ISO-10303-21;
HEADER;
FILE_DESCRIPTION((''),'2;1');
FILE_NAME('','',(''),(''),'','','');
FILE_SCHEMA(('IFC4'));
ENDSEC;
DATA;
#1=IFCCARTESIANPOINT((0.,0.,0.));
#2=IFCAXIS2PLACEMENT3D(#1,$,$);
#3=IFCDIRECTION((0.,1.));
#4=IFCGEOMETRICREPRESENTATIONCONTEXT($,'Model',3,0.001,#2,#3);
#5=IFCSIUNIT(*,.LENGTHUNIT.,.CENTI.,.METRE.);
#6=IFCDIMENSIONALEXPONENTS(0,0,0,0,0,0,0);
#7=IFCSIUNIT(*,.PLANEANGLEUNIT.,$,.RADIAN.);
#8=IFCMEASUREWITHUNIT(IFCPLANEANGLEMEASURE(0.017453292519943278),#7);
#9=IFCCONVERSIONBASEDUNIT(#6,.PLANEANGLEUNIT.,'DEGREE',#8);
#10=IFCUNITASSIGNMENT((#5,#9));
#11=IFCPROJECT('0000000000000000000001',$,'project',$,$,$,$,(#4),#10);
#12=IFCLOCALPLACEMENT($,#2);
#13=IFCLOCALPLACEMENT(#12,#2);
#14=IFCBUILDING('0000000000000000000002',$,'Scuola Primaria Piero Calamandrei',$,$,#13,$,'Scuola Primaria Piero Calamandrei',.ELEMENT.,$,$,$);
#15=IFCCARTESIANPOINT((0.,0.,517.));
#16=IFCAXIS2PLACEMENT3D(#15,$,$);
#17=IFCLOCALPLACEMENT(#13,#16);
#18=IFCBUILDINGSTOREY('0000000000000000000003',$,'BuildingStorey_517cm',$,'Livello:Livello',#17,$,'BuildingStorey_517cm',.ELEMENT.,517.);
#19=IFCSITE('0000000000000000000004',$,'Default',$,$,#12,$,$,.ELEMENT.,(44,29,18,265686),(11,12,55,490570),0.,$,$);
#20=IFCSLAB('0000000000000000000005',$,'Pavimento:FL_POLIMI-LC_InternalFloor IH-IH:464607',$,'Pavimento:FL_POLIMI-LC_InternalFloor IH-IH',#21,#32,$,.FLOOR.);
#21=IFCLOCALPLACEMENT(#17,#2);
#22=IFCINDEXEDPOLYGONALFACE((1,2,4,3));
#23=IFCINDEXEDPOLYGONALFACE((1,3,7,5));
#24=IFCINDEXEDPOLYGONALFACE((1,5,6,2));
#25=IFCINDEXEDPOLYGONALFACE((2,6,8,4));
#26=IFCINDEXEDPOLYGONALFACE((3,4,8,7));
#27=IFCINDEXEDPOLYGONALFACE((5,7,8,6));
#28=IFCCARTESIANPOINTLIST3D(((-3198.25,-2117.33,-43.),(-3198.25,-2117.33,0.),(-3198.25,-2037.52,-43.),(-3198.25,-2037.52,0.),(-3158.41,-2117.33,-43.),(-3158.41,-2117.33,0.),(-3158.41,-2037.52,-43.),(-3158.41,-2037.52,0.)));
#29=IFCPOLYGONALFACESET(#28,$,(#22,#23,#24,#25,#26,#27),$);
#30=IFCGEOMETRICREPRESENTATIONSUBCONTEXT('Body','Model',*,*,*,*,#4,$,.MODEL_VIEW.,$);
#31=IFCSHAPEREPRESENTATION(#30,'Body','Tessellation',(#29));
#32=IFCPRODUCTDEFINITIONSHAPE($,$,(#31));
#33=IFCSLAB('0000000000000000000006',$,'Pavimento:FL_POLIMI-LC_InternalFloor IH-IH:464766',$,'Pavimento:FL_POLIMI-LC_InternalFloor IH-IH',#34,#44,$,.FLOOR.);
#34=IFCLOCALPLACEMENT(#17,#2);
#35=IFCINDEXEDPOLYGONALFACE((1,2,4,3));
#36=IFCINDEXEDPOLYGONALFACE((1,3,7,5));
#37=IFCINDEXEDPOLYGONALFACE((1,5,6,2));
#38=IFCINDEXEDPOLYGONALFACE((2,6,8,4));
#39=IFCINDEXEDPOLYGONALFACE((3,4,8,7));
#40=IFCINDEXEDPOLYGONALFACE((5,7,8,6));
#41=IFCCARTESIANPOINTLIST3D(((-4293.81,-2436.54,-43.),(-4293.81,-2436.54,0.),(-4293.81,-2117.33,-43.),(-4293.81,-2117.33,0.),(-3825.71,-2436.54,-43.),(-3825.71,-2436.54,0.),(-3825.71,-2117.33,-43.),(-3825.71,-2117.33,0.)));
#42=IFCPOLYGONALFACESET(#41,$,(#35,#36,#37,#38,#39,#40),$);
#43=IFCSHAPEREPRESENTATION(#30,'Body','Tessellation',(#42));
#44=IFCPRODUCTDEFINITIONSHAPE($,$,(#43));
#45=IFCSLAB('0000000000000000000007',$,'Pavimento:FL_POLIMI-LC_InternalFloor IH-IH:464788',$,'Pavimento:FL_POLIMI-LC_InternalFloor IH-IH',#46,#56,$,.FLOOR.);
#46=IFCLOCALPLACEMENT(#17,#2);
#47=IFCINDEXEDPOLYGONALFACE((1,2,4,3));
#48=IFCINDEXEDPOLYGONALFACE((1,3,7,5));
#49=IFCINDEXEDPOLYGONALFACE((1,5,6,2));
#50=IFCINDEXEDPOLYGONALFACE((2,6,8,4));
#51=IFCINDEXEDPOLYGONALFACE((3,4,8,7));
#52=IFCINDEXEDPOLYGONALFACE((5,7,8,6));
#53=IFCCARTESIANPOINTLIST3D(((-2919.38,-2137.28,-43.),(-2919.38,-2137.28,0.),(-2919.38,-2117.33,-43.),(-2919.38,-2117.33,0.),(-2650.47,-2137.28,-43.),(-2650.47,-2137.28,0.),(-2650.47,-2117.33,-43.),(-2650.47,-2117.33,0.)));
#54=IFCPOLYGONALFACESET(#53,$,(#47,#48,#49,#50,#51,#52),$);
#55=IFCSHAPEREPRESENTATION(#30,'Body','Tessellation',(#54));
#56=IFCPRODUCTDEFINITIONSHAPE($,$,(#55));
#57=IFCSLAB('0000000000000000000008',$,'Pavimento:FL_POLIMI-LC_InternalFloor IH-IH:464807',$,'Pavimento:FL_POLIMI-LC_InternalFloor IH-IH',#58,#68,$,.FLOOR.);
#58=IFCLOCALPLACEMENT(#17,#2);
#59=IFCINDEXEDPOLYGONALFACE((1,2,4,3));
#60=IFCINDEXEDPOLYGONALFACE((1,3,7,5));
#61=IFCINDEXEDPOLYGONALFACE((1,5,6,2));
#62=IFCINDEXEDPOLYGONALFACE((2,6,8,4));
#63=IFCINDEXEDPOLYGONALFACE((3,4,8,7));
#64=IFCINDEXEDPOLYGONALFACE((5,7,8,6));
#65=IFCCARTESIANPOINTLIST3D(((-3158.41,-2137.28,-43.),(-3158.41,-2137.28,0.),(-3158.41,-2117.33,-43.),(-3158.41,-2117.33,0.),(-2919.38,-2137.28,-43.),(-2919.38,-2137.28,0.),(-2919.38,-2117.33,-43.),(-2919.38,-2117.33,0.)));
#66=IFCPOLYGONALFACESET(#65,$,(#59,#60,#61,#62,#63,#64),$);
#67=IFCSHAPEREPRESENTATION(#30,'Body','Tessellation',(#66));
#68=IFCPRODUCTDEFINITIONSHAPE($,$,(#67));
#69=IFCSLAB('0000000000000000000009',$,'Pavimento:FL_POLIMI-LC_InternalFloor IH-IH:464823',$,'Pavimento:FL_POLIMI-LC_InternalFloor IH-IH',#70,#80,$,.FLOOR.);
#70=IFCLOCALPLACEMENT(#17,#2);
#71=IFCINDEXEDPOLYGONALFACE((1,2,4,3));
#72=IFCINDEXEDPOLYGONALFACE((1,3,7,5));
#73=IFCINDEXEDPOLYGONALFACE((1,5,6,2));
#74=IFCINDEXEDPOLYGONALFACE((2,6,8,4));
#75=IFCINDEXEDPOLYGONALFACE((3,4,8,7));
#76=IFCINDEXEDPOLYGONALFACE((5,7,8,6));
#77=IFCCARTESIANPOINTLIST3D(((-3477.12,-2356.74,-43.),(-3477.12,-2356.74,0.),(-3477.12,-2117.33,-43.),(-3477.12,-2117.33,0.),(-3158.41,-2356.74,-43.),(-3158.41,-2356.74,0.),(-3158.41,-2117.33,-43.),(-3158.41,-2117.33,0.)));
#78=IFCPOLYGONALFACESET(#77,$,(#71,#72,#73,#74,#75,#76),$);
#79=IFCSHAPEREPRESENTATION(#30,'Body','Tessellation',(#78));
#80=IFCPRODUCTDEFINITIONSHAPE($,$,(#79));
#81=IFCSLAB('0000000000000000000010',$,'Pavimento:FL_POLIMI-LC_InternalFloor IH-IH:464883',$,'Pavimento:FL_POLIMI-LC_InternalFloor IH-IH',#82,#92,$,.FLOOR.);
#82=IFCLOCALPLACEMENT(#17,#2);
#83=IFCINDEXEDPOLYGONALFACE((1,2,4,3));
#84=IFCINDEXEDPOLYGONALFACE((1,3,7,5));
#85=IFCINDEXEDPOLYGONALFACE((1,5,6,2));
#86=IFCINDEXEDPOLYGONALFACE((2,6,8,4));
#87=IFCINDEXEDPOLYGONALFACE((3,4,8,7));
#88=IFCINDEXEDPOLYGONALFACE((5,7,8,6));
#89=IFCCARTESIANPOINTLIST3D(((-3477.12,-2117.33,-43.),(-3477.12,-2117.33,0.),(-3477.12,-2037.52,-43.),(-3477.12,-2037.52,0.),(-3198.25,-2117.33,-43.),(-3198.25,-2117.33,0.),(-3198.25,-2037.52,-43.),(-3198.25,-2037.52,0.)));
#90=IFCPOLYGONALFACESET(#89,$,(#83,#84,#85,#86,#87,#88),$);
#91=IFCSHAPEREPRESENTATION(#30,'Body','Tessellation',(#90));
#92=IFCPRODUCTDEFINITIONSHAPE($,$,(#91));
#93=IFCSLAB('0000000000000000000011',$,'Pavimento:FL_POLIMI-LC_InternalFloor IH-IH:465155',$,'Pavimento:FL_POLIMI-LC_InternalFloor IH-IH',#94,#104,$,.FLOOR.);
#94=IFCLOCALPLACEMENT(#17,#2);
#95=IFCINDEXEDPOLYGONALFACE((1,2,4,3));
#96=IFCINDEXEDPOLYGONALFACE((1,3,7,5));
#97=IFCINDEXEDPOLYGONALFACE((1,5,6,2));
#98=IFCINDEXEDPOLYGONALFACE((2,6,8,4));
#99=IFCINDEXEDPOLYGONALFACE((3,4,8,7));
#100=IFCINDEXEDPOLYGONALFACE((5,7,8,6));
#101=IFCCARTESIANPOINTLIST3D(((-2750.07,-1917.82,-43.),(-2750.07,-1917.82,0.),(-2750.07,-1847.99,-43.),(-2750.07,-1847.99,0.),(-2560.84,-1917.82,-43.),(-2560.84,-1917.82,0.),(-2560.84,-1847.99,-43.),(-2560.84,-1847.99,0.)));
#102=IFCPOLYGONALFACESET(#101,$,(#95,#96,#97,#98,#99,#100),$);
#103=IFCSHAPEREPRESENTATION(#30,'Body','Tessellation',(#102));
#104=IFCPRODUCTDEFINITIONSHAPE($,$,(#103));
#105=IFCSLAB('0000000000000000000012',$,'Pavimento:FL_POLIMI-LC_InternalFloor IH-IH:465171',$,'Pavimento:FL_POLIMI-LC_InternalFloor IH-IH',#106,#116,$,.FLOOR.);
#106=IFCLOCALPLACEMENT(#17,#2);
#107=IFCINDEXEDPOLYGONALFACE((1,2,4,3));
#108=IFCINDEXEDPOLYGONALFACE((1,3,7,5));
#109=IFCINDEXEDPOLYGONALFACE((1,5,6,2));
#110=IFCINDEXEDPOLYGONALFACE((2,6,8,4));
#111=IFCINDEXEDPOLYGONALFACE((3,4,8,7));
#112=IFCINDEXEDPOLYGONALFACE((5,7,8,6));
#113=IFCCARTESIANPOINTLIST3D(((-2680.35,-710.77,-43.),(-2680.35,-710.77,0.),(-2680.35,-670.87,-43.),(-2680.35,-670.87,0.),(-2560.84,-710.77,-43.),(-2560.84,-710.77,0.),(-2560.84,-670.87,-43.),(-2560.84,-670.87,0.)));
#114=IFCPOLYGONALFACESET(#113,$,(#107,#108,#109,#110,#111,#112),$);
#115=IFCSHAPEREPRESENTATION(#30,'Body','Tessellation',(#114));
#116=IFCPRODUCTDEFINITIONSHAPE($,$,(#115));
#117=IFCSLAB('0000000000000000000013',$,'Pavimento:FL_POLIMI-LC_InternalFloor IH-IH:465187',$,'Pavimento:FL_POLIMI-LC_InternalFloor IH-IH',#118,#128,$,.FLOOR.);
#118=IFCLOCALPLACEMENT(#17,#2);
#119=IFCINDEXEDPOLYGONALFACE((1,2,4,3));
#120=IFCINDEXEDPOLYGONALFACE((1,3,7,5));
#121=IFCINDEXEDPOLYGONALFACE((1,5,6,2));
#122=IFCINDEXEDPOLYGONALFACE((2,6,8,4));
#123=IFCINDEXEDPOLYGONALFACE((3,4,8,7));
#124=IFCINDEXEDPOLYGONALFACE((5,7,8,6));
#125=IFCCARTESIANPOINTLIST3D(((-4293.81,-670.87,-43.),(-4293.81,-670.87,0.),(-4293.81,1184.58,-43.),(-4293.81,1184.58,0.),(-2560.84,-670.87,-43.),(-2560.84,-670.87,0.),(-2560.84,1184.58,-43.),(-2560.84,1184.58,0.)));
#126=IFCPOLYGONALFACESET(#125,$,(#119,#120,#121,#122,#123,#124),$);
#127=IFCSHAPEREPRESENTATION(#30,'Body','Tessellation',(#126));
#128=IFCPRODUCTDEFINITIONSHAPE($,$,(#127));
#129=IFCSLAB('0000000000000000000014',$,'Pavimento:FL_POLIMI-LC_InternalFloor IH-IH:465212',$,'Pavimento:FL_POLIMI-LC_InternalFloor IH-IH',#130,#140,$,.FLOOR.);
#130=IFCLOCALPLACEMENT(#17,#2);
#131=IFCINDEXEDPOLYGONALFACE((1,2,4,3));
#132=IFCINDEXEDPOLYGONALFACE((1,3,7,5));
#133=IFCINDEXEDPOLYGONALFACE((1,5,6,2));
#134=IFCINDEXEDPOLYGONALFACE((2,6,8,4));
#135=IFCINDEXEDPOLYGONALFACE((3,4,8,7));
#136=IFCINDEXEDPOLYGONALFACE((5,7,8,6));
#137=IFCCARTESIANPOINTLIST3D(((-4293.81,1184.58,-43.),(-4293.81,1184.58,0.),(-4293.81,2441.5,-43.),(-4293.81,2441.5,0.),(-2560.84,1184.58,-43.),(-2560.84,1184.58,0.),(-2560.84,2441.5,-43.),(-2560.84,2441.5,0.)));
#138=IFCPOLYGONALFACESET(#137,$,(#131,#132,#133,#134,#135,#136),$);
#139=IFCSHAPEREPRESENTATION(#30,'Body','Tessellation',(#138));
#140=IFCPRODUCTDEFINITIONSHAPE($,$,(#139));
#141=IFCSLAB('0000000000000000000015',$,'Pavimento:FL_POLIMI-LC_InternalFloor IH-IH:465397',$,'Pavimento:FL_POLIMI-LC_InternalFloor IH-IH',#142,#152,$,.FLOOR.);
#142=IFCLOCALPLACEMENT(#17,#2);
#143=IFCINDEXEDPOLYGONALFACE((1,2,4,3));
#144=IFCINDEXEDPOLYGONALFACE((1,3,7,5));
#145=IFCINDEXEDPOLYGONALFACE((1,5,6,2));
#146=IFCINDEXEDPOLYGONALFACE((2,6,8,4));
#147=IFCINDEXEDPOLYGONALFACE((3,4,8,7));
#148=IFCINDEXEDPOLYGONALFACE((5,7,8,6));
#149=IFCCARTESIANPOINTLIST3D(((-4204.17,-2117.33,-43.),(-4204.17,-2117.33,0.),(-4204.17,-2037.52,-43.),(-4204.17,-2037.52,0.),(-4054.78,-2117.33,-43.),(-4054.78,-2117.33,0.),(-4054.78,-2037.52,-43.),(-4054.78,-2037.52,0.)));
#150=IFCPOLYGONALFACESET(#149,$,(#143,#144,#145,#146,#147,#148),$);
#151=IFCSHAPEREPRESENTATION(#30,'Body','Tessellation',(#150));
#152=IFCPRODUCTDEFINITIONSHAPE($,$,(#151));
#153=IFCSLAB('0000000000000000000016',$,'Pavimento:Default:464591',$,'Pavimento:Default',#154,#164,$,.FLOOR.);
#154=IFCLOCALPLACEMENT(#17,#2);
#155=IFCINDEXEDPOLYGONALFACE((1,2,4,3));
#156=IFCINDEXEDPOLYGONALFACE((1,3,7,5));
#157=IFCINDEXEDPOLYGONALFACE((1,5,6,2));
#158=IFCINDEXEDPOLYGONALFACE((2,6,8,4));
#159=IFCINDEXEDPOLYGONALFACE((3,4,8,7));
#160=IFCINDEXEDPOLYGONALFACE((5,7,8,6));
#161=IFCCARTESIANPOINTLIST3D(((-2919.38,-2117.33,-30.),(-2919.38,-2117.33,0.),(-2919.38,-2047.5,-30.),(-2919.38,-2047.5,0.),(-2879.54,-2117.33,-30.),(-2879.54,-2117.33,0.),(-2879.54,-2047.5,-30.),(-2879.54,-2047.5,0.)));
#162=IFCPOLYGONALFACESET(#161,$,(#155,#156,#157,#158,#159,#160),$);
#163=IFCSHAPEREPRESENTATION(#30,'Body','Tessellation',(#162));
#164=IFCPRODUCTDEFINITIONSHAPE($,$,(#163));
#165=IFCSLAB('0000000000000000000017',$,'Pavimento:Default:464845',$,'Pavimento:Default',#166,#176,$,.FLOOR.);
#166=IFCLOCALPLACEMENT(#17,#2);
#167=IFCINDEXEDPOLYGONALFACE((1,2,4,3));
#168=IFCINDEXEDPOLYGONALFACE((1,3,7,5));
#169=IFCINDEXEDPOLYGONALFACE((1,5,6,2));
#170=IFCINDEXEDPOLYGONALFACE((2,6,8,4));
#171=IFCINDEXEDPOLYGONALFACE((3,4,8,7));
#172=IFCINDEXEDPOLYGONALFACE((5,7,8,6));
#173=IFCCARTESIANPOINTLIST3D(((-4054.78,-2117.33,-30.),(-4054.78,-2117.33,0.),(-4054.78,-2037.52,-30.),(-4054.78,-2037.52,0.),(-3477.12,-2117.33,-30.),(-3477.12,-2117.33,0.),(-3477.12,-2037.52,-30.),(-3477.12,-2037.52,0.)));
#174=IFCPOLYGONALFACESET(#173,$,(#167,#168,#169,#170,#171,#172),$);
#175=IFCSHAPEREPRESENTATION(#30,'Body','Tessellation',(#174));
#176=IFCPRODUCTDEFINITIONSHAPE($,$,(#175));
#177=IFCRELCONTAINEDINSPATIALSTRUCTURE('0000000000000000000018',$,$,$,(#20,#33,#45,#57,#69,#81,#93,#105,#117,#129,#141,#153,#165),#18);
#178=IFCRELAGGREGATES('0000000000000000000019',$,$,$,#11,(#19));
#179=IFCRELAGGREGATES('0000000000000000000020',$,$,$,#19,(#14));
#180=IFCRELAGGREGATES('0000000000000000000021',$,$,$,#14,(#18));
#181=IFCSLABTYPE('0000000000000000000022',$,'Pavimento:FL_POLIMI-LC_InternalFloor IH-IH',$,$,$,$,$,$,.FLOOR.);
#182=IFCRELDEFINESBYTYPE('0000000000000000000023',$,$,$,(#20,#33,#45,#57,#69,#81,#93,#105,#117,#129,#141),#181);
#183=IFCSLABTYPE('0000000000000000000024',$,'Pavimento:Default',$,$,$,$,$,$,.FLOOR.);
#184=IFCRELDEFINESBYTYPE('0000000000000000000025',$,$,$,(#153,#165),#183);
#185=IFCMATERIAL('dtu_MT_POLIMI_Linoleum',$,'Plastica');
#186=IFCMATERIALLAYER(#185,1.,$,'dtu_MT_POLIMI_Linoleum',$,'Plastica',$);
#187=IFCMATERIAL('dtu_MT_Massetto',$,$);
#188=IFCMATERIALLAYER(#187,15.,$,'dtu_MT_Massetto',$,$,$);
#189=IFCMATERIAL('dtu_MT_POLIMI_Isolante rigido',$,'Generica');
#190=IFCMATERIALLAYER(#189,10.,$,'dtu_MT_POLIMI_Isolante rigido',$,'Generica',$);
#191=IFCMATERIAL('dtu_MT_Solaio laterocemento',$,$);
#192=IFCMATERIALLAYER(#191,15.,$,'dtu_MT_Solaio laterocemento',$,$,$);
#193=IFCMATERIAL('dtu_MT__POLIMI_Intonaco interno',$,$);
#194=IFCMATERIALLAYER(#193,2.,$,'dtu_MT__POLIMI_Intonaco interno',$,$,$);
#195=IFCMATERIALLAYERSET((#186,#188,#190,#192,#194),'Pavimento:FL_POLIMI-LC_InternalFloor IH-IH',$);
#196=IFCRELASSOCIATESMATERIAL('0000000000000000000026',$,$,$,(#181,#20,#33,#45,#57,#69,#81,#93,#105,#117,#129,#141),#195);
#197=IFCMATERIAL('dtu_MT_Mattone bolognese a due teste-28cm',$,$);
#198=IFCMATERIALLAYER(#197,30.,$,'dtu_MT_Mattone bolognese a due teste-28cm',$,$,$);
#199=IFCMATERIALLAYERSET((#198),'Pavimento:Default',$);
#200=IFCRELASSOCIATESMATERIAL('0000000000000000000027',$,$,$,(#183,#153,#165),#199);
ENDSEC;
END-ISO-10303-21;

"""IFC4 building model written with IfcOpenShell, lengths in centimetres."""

from ifc_helpers import new_model, entity, si_unit, converted_unit, direction, frame, frame_2d, origin, origin_2d_with_axis, place, context, subcontext, project, spatial, rectangle, extrude, material, layer, layer_set, layer_usage, type_object, element, save


model = new_model("IFC4")

# Units and contexts
model_context = context("Model", 3, precision=0.001, world=origin(), true_north=direction((0.0, 1.0)))
body_context = subcontext(model_context, "Body", "Model", "MODEL_VIEW")
ifc_project = project(units=[si_unit("LENGTHUNIT", "METRE", prefix="CENTI"), converted_unit("PLANEANGLEUNIT", "DEGREE", entity("IfcPlaneAngleMeasure", 0.017453292519943278), si_unit("PLANEANGLEUNIT", "RADIAN"), dimensions=[0, 0, 0, 0, 0, 0, 0])], contexts=[model_context])

# Site, building, storey
site_placement = place(None, origin())
site = spatial("IfcSite", under=ifc_project, at=site_placement, Name="Default", CompositionType="ELEMENT", RefLatitude=(44, 29, 18, 265686), RefLongitude=(11, 12, 55, 490570), RefElevation=0.0)
building_placement = place(site_placement, origin())
building = spatial("IfcBuilding", under=site, at=building_placement, Name="Scuola Primaria Piero Calamandrei", LongName="Scuola Primaria Piero Calamandrei", CompositionType="ELEMENT")
storey_placement = place(building_placement, frame((0.0, 0.0, 517.0)))
storey = spatial("IfcBuildingStorey", under=building, at=storey_placement, Name="BuildingStorey_517cm", ObjectType="Livello:Livello", LongName="BuildingStorey_517cm", CompositionType="ELEMENT", Elevation=517.0)

# Slabs
ifc_material_1 = material(Name="dtu_MT_POLIMI_Linoleum", Category="Plastica")
ifc_layer_1 = layer(ifc_material_1, 1.0, Name="dtu_MT_POLIMI_Linoleum", Category="Plastica")
ifc_material_2 = material(Name="dtu_MT_Massetto")
ifc_layer_2 = layer(ifc_material_2, 15.0, Name="dtu_MT_Massetto")
ifc_material_3 = material(Name="dtu_MT_POLIMI_Isolante rigido", Category="Generica")
ifc_layer_3 = layer(ifc_material_3, 10.0, Name="dtu_MT_POLIMI_Isolante rigido", Category="Generica")
ifc_material_4 = material(Name="dtu_MT_Solaio laterocemento")
ifc_layer_4 = layer(ifc_material_4, 15.0, Name="dtu_MT_Solaio laterocemento")
ifc_material_5 = material(Name="dtu_MT__POLIMI_Intonaco interno")
ifc_layer_5 = layer(ifc_material_5, 2.0, Name="dtu_MT__POLIMI_Intonaco interno")
ifc_layer_set_1 = layer_set([ifc_layer_1, ifc_layer_2, ifc_layer_3, ifc_layer_4, ifc_layer_5], Name="Pavimento:FL_POLIMI-LC_InternalFloor IH-IH")
slab_type_1 = type_object("IfcSlabType", Name="Pavimento:FL_POLIMI-LC_InternalFloor IH-IH", PredefinedType="FLOOR", material=ifc_layer_set_1)
ifc_layer_usage_1 = layer_usage(ifc_layer_set_1, "AXIS3", "POSITIVE", 0.0)
slab_1_placement = place(storey_placement, origin())
element("IfcSlab", 1, at=slab_1_placement, inside=storey, type_object=slab_type_1, material=ifc_layer_usage_1, Name="Pavimento:FL_POLIMI-LC_InternalFloor IH-IH:464607", ObjectType="Pavimento:FL_POLIMI-LC_InternalFloor IH-IH", PredefinedType="FLOOR", context=body_context, shape_type="SweptSolid", body=[
    extrude(rectangle(XDim=79.8, YDim=39.84, at=frame_2d((0.0, 0.0), x_axis=(1.0, 0.0))), frame((-3178.33, -2077.42, 0.0), z_axis=(0.0, 0.0, -1.0), x_axis=(0.0, 1.0, 0.0)), (0.0, 0.0, 1.0), 43.0),
])
ifc_layer_usage_2 = layer_usage(ifc_layer_set_1, "AXIS3", "POSITIVE", 0.0)
slab_2_placement = place(storey_placement, origin())
element("IfcSlab", 2, at=slab_2_placement, inside=storey, type_object=slab_type_1, material=ifc_layer_usage_2, Name="Pavimento:FL_POLIMI-LC_InternalFloor IH-IH:464766", ObjectType="Pavimento:FL_POLIMI-LC_InternalFloor IH-IH", PredefinedType="FLOOR", context=body_context, shape_type="SweptSolid", body=[
    extrude(rectangle(XDim=319.22, YDim=468.1, at=frame_2d((0.0, 0.0), x_axis=(1.0, 0.0))), frame((-4059.76, -2276.94, 0.0), z_axis=(0.0, 0.0, -1.0), x_axis=(0.0, 1.0, 0.0)), (0.0, 0.0, 1.0), 43.0),
])
ifc_layer_usage_3 = layer_usage(ifc_layer_set_1, "AXIS3", "POSITIVE", 0.0)
slab_3_placement = place(storey_placement, origin())
element("IfcSlab", 3, at=slab_3_placement, inside=storey, type_object=slab_type_1, material=ifc_layer_usage_3, Name="Pavimento:FL_POLIMI-LC_InternalFloor IH-IH:464788", ObjectType="Pavimento:FL_POLIMI-LC_InternalFloor IH-IH", PredefinedType="FLOOR", context=body_context, shape_type="SweptSolid", body=[
    extrude(rectangle(XDim=19.95, YDim=268.91, at=frame_2d((0.0, 0.0), x_axis=(1.0, 0.0))), frame((-2784.93, -2127.3, 0.0), z_axis=(0.0, 0.0, -1.0), x_axis=(0.0, 1.0, 0.0)), (0.0, 0.0, 1.0), 43.0),
])
ifc_layer_usage_4 = layer_usage(ifc_layer_set_1, "AXIS3", "POSITIVE", 0.0)
slab_4_placement = place(storey_placement, origin())
element("IfcSlab", 4, at=slab_4_placement, inside=storey, type_object=slab_type_1, material=ifc_layer_usage_4, Name="Pavimento:FL_POLIMI-LC_InternalFloor IH-IH:464807", ObjectType="Pavimento:FL_POLIMI-LC_InternalFloor IH-IH", PredefinedType="FLOOR", context=body_context, shape_type="SweptSolid", body=[
    extrude(rectangle(XDim=19.95, YDim=239.03, at=frame_2d((0.0, 0.0), x_axis=(1.0, 0.0))), frame((-3038.9, -2127.3, 0.0), z_axis=(0.0, 0.0, -1.0), x_axis=(0.0, 1.0, 0.0)), (0.0, 0.0, 1.0), 43.0),
])
ifc_layer_usage_5 = layer_usage(ifc_layer_set_1, "AXIS3", "POSITIVE", 0.0)
slab_5_placement = place(storey_placement, origin())
element("IfcSlab", 5, at=slab_5_placement, inside=storey, type_object=slab_type_1, material=ifc_layer_usage_5, Name="Pavimento:FL_POLIMI-LC_InternalFloor IH-IH:464823", ObjectType="Pavimento:FL_POLIMI-LC_InternalFloor IH-IH", PredefinedType="FLOOR", context=body_context, shape_type="SweptSolid", body=[
    extrude(rectangle(XDim=239.41, YDim=318.71, at=origin_2d_with_axis()), frame((-3317.77, -2237.03, 0.0), z_axis=(0.0, 0.0, -1.0), x_axis=(0.0, 1.0, 0.0)), (0.0, 0.0, 1.0), 43.0),
])
ifc_layer_usage_6 = layer_usage(ifc_layer_set_1, "AXIS3", "POSITIVE", 0.0)
slab_6_placement = place(storey_placement, origin())
element("IfcSlab", 6, at=slab_6_placement, inside=storey, type_object=slab_type_1, material=ifc_layer_usage_6, Name="Pavimento:FL_POLIMI-LC_InternalFloor IH-IH:464883", ObjectType="Pavimento:FL_POLIMI-LC_InternalFloor IH-IH", PredefinedType="FLOOR", context=body_context, shape_type="SweptSolid", body=[
    extrude(rectangle(XDim=79.8, YDim=278.87, at=frame_2d((0.0, 0.0), x_axis=(1.0, 0.0))), frame((-3337.69, -2077.42, 0.0), z_axis=(0.0, 0.0, -1.0), x_axis=(0.0, 1.0, 0.0)), (0.0, 0.0, 1.0), 43.0),
])
ifc_layer_usage_7 = layer_usage(ifc_layer_set_1, "AXIS3", "POSITIVE", 0.0)
slab_7_placement = place(storey_placement, origin())
element("IfcSlab", 7, at=slab_7_placement, inside=storey, type_object=slab_type_1, material=ifc_layer_usage_7, Name="Pavimento:FL_POLIMI-LC_InternalFloor IH-IH:465155", ObjectType="Pavimento:FL_POLIMI-LC_InternalFloor IH-IH", PredefinedType="FLOOR", context=body_context, shape_type="SweptSolid", body=[
    extrude(rectangle(XDim=69.83, YDim=189.23, at=frame_2d((0.0, 0.0), x_axis=(1.0, 0.0))), frame((-2655.45, -1882.9, 0.0), z_axis=(0.0, 0.0, -1.0), x_axis=(0.0, 1.0, 0.0)), (0.0, 0.0, 1.0), 43.0),
])
ifc_layer_usage_8 = layer_usage(ifc_layer_set_1, "AXIS3", "POSITIVE", 0.0)
slab_8_placement = place(storey_placement, origin())
element("IfcSlab", 8, at=slab_8_placement, inside=storey, type_object=slab_type_1, material=ifc_layer_usage_8, Name="Pavimento:FL_POLIMI-LC_InternalFloor IH-IH:465171", ObjectType="Pavimento:FL_POLIMI-LC_InternalFloor IH-IH", PredefinedType="FLOOR", context=body_context, shape_type="SweptSolid", body=[
    extrude(rectangle(XDim=39.9, YDim=119.52, at=frame_2d((0.0, 0.0), x_axis=(1.0, 0.0))), frame((-2620.59, -690.82, 0.0), z_axis=(0.0, 0.0, -1.0), x_axis=(0.0, 1.0, 0.0)), (0.0, 0.0, 1.0), 43.0),
])
ifc_layer_usage_9 = layer_usage(ifc_layer_set_1, "AXIS3", "POSITIVE", 0.0)
slab_9_placement = place(storey_placement, origin())
element("IfcSlab", 9, at=slab_9_placement, inside=storey, type_object=slab_type_1, material=ifc_layer_usage_9, Name="Pavimento:FL_POLIMI-LC_InternalFloor IH-IH:465187", ObjectType="Pavimento:FL_POLIMI-LC_InternalFloor IH-IH", PredefinedType="FLOOR", context=body_context, shape_type="SweptSolid", body=[
    extrude(rectangle(XDim=1855.45, YDim=1732.97, at=frame_2d((0.0, 0.0), x_axis=(1.0, 0.0))), frame((-3427.32, 256.86, 0.0), z_axis=(0.0, 0.0, -1.0), x_axis=(0.0, 1.0, 0.0)), (0.0, 0.0, 1.0), 43.0),
])
ifc_layer_usage_10 = layer_usage(ifc_layer_set_1, "AXIS3", "POSITIVE", 0.0)
slab_10_placement = place(storey_placement, origin())
element("IfcSlab", 10, at=slab_10_placement, inside=storey, type_object=slab_type_1, material=ifc_layer_usage_10, Name="Pavimento:FL_POLIMI-LC_InternalFloor IH-IH:465212", ObjectType="Pavimento:FL_POLIMI-LC_InternalFloor IH-IH", PredefinedType="FLOOR", context=body_context, shape_type="SweptSolid", body=[
    extrude(rectangle(XDim=1256.92, YDim=1732.97, at=frame_2d((0.0, 0.0), x_axis=(1.0, 0.0))), frame((-3427.32, 1813.04, 0.0), z_axis=(0.0, 0.0, -1.0), x_axis=(0.0, 1.0, 0.0)), (0.0, 0.0, 1.0), 43.0),
])
ifc_layer_usage_11 = layer_usage(ifc_layer_set_1, "AXIS3", "POSITIVE", 0.0)
slab_11_placement = place(storey_placement, origin())
element("IfcSlab", 11, at=slab_11_placement, inside=storey, type_object=slab_type_1, material=ifc_layer_usage_11, Name="Pavimento:FL_POLIMI-LC_InternalFloor IH-IH:465397", ObjectType="Pavimento:FL_POLIMI-LC_InternalFloor IH-IH", PredefinedType="FLOOR", context=body_context, shape_type="SweptSolid", body=[
    extrude(rectangle(XDim=79.8, YDim=149.39, at=frame_2d((0.0, 0.0), x_axis=(1.0, 0.0))), frame((-4129.48, -2077.42, 0.0), z_axis=(0.0, 0.0, -1.0), x_axis=(0.0, 1.0, 0.0)), (0.0, 0.0, 1.0), 43.0),
])
ifc_material_6 = material(Name="dtu_MT_Mattone bolognese a due teste-28cm")
ifc_layer_6 = layer(ifc_material_6, 30.0, Name="dtu_MT_Mattone bolognese a due teste-28cm")
ifc_layer_set_2 = layer_set([ifc_layer_6], Name="Pavimento:Default")
ifc_layer_usage_12 = layer_usage(ifc_layer_set_2, "AXIS3", "POSITIVE", 0.0)
slab_type_2 = type_object("IfcSlabType", Name="Pavimento:Default", PredefinedType="FLOOR", material=ifc_layer_set_2)
slab_12_placement = place(storey_placement, origin())
element("IfcSlab", 12, at=slab_12_placement, inside=storey, type_object=slab_type_2, material=ifc_layer_usage_12, Name="Pavimento:Default:464591", ObjectType="Pavimento:Default", PredefinedType="FLOOR", context=body_context, shape_type="SweptSolid", body=[
    extrude(rectangle(XDim=69.83, YDim=39.84, at=frame_2d((0.0, 0.0), x_axis=(1.0, 0.0))), frame((-2899.46, -2082.41, 0.0), z_axis=(0.0, 0.0, -1.0), x_axis=(0.0, 1.0, 0.0)), (0.0, 0.0, 1.0), 30.0),
])
ifc_layer_usage_13 = layer_usage(ifc_layer_set_2, "AXIS3", "POSITIVE", 0.0)
slab_13_placement = place(storey_placement, origin())
element("IfcSlab", 13, at=slab_13_placement, inside=storey, type_object=slab_type_2, material=ifc_layer_usage_13, Name="Pavimento:Default:464845", ObjectType="Pavimento:Default", PredefinedType="FLOOR", context=body_context, shape_type="SweptSolid", body=[
    extrude(rectangle(XDim=79.8, YDim=577.66, at=frame_2d((0.0, 0.0), x_axis=(1.0, 0.0))), frame((-3765.95, -2077.42, 0.0), z_axis=(0.0, 0.0, -1.0), x_axis=(0.0, 1.0, 0.0)), (0.0, 0.0, 1.0), 30.0),
])

save(model, "model.ifc")
